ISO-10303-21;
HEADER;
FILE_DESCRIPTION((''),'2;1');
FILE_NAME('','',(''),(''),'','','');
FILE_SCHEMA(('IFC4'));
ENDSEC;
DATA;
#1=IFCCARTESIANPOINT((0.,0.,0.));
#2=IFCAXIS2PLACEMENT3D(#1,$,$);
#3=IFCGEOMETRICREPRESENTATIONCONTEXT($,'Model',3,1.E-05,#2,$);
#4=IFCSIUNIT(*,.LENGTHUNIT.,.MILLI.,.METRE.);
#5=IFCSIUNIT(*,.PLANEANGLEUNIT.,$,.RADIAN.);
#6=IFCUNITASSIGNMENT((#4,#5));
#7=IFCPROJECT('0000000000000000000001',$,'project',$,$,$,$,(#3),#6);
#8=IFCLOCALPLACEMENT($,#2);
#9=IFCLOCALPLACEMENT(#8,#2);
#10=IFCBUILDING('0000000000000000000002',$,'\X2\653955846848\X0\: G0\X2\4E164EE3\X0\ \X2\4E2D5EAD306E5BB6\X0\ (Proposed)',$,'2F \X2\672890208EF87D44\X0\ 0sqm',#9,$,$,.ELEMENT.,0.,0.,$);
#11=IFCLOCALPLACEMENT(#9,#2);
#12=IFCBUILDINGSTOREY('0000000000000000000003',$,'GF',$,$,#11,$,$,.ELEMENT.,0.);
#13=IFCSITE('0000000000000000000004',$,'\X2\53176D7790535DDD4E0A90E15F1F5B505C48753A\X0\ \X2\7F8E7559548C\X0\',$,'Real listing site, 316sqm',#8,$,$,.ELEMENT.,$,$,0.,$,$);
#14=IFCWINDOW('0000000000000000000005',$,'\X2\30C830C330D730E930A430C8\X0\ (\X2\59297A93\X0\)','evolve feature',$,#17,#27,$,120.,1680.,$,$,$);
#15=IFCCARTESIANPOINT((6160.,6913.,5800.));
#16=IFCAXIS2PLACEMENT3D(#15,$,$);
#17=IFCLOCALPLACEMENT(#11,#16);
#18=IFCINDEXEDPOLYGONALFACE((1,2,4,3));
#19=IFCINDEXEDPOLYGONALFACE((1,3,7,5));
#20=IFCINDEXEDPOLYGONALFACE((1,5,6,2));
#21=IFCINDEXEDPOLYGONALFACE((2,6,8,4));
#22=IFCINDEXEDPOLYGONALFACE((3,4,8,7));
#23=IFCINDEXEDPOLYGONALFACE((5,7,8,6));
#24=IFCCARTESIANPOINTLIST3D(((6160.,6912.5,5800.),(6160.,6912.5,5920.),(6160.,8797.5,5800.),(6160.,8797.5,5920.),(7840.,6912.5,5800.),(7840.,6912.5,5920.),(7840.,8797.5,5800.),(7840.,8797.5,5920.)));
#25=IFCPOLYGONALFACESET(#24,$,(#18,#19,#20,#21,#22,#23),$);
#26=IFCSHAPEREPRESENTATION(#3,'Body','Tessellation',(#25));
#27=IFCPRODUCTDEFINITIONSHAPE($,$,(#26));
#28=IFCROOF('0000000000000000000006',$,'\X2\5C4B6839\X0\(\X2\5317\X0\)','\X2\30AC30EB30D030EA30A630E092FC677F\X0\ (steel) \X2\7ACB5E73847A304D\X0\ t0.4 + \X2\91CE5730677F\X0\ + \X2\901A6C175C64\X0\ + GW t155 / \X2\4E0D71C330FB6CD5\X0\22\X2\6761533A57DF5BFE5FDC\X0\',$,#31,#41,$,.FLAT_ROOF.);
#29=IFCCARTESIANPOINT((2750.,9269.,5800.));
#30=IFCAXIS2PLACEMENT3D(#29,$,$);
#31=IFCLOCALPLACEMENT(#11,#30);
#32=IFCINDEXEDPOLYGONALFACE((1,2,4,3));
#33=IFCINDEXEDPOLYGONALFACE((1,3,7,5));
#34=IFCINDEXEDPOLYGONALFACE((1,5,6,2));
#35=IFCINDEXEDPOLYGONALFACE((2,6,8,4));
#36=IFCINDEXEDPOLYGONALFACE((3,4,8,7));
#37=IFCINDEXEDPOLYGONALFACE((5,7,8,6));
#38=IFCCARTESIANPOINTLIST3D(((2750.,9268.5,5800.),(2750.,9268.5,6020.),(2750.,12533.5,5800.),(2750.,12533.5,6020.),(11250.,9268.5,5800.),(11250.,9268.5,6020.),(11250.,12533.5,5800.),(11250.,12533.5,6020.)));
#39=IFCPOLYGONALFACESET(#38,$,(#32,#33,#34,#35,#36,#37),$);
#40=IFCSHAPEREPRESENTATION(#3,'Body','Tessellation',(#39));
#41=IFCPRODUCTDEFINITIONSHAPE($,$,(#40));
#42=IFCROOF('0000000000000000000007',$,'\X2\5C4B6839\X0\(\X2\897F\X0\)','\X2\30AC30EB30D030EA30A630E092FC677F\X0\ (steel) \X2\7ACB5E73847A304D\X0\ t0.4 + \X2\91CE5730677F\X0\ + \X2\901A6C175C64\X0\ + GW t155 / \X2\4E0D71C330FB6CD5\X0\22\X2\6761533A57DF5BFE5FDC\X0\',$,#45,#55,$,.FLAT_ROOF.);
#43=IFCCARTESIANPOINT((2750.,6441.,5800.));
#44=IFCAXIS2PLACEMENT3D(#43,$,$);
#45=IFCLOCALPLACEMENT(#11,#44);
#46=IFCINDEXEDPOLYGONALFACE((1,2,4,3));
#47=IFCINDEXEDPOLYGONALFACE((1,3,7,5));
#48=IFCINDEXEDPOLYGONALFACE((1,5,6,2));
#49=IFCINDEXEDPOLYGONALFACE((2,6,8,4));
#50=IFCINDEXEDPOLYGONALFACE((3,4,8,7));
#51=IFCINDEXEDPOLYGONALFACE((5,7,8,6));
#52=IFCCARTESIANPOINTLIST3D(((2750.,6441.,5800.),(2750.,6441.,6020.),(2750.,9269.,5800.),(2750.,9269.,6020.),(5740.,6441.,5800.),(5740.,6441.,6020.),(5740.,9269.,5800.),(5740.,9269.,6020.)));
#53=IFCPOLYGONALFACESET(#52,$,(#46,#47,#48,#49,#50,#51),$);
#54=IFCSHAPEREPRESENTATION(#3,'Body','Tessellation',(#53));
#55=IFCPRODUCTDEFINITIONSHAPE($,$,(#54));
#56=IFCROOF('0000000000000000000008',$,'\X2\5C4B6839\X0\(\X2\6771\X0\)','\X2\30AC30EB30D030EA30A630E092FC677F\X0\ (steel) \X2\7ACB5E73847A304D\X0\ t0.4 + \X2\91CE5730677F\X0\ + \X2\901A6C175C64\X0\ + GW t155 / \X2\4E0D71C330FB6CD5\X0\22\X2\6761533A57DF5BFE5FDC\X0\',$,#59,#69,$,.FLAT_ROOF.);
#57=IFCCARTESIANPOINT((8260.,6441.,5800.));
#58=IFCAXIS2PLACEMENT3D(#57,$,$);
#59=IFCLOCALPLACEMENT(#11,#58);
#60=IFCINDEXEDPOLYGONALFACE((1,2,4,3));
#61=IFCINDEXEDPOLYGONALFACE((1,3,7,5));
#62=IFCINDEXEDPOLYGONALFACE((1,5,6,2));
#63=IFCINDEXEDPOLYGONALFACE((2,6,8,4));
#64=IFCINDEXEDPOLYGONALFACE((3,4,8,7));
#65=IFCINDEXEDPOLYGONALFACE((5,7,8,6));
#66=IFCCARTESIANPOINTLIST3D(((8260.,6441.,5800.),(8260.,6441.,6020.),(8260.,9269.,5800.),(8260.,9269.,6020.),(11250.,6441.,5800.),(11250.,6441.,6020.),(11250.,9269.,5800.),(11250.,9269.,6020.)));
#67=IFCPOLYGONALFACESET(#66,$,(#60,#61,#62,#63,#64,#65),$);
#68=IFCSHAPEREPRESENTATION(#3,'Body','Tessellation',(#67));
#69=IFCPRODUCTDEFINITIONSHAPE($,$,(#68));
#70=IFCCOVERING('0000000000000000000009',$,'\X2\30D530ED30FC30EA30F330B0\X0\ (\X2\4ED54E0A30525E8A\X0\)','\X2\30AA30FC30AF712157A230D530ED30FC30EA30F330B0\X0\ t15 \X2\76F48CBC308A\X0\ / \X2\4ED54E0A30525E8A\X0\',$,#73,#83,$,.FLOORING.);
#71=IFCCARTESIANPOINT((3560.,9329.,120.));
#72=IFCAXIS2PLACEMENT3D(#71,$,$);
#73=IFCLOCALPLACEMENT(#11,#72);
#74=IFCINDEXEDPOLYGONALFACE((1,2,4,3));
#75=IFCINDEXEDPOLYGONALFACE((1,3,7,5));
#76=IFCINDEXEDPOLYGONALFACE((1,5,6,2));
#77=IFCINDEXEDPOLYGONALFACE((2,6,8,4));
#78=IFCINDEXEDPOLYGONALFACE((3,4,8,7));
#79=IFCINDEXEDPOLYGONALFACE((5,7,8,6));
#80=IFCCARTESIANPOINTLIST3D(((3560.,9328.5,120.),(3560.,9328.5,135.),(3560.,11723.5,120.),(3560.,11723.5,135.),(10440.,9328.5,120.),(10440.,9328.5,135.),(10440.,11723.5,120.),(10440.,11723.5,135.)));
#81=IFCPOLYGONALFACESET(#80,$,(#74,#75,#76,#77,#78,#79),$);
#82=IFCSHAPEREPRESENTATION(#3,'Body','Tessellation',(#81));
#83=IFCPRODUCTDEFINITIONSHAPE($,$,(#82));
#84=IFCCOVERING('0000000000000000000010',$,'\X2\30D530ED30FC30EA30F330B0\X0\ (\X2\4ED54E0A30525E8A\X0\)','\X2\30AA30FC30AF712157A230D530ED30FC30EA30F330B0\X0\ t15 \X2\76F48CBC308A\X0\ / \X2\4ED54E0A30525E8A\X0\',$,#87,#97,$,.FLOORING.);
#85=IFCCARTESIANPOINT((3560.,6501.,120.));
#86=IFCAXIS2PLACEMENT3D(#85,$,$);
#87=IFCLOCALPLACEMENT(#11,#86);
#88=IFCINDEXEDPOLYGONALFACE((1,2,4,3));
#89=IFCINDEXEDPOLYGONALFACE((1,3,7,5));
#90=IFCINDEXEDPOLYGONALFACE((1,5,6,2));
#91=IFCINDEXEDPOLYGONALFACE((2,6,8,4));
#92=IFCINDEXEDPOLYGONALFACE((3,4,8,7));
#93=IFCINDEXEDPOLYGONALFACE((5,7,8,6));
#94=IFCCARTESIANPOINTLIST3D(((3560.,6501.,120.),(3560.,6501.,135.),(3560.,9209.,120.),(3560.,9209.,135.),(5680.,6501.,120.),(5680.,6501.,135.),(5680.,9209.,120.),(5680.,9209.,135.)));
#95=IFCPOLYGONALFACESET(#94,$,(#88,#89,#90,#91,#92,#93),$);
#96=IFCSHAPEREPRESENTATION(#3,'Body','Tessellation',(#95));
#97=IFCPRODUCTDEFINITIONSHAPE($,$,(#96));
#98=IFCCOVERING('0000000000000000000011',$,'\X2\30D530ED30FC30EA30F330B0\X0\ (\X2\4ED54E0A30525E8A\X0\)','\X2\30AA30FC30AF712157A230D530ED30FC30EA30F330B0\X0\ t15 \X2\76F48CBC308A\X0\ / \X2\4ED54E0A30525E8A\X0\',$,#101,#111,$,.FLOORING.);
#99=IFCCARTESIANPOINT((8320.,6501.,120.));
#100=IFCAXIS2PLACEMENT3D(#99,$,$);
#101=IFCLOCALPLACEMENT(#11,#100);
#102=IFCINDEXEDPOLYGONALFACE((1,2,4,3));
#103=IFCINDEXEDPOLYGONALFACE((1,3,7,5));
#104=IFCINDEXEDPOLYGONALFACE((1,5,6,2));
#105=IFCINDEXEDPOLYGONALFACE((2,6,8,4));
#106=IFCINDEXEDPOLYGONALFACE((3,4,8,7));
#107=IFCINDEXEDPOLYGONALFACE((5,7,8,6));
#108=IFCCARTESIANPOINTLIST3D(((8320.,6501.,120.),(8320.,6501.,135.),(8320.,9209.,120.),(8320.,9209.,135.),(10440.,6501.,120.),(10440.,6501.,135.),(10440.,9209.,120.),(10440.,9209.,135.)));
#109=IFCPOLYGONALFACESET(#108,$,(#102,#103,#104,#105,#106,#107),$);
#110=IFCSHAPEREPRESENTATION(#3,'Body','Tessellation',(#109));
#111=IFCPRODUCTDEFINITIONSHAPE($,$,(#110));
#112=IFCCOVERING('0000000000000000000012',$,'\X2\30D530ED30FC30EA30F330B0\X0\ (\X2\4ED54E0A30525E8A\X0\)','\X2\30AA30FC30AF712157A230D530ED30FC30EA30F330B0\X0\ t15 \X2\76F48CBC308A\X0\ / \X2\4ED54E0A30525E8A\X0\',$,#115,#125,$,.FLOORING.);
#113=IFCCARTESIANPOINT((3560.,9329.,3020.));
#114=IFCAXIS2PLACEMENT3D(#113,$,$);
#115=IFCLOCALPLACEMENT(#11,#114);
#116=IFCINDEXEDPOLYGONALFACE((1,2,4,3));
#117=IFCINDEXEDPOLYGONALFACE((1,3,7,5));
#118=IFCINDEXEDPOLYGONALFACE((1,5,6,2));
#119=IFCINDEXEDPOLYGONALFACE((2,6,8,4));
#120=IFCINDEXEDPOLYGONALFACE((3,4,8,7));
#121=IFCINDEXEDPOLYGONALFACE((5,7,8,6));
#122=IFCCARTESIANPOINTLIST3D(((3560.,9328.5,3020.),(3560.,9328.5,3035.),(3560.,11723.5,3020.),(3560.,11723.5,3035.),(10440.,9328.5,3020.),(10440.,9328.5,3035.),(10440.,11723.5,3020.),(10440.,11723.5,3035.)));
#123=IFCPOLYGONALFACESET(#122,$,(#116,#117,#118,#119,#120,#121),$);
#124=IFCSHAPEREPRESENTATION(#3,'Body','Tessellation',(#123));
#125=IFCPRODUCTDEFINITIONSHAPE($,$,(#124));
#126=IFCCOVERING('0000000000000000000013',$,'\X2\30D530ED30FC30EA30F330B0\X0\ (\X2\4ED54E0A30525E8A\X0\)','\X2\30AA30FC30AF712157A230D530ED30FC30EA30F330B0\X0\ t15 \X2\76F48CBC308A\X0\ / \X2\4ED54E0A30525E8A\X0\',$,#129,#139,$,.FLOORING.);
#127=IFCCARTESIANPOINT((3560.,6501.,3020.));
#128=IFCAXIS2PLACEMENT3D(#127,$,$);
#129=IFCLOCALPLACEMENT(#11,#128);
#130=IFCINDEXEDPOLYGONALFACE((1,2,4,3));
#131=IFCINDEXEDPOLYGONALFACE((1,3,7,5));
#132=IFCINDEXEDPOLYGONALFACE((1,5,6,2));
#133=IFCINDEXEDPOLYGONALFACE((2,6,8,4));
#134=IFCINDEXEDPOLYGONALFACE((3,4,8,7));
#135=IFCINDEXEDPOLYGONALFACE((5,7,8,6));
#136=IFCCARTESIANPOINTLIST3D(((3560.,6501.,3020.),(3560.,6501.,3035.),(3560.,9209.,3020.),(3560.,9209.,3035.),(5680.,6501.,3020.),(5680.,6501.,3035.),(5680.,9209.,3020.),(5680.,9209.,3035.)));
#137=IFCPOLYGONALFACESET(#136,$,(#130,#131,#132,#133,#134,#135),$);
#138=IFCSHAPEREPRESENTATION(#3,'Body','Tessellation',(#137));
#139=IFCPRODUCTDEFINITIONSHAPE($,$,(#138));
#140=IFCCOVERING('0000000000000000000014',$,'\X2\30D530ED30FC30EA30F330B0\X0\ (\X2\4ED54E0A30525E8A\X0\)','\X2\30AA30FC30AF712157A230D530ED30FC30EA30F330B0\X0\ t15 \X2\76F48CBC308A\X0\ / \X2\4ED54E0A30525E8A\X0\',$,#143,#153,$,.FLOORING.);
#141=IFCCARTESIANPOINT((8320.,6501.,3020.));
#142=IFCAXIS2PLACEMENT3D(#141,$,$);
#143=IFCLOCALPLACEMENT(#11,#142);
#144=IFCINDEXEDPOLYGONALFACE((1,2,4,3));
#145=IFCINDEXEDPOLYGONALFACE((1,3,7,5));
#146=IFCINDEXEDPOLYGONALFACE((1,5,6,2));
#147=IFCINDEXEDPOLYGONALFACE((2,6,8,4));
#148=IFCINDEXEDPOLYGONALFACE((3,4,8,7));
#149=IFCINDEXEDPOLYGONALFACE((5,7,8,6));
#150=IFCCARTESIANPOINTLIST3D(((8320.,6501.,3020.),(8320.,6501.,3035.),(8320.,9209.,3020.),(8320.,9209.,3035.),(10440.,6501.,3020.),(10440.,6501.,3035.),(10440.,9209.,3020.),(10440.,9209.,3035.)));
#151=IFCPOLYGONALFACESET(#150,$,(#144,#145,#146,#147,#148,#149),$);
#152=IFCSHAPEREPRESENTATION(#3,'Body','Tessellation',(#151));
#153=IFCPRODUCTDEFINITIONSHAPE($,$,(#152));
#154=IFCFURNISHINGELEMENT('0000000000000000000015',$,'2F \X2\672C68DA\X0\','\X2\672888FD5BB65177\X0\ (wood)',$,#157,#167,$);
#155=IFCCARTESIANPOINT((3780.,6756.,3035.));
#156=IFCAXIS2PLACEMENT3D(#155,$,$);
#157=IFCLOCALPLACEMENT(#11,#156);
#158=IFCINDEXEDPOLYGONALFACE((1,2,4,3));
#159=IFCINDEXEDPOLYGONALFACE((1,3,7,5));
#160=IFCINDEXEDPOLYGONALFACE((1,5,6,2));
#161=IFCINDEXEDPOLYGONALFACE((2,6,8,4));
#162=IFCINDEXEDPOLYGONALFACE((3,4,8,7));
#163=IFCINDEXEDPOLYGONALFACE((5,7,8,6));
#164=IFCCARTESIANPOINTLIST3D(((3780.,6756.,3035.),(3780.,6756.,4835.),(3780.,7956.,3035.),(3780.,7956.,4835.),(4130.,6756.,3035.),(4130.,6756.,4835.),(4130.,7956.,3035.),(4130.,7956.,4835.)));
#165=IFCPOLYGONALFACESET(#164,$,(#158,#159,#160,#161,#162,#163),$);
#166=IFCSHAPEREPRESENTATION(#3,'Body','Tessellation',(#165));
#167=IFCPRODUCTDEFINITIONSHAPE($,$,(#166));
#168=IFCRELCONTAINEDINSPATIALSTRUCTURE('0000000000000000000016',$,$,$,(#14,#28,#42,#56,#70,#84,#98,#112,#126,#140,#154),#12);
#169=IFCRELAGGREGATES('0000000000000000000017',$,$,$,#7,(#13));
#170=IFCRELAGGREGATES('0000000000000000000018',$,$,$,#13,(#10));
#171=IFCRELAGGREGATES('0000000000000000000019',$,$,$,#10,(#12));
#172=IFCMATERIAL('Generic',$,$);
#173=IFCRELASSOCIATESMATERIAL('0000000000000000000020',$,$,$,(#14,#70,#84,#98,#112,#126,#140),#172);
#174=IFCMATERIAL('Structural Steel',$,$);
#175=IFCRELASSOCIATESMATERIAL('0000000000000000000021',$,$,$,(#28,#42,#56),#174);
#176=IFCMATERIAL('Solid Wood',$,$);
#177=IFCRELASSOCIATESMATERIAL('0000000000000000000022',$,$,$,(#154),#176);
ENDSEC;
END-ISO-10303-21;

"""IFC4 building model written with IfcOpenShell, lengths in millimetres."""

from ifc_helpers import new_model, si_unit, frame, frame_2d, origin, place, context, project, spatial, rectangle, extrude, material, element, save


model = new_model("IFC4")

# Units and contexts
model_context = context("Model", 3, precision=1e-05, world=origin())
ifc_project = project(units=[si_unit("LENGTHUNIT", "METRE", prefix="MILLI"), si_unit("PLANEANGLEUNIT", "RADIAN")], contexts=[model_context])

# Site, building, storey
site_placement = place(None, origin())
site = spatial("IfcSite", under=ifc_project, at=site_placement, Name="北海道川上郡弟子屈町 美留和", ObjectType="Real listing site, 316sqm", CompositionType="ELEMENT", RefElevation=0.0)
building_placement = place(site_placement, origin())
building = spatial("IfcBuilding", under=site, at=building_placement, Name="改善案: G0世代 中庭の家 (Proposed)", ObjectType="2F 木造軸組 0sqm", CompositionType="ELEMENT", ElevationOfRefHeight=0.0, ElevationOfTerrain=0.0)
storey_placement = place(building_placement, origin())
storey = spatial("IfcBuildingStorey", under=building, at=storey_placement, Name="GF", CompositionType="ELEMENT", Elevation=0.0)

# Shared definitions
ifc_material_1 = material(Name="Solid Wood")

# Window
ifc_material_2 = material(Name="Generic")
window_1_placement = place(storey_placement, frame((6160.0, 6913.0, 5800.0)))
element("IfcWindow", 1, at=window_1_placement, inside=storey, material=ifc_material_2, Name="トップライト (天窓)", Description="evolve feature", OverallHeight=120.0, OverallWidth=1680.0, context=model_context, shape_type="SweptSolid", body=[
    extrude(rectangle(XDim=1680.0, YDim=1885.0, at=frame_2d((840.0, 942.0))), frame((6160.0, 6913.0, 5800.0)), (0.0, 0.0, 1.0), 120.0),
])

# Roofs
ifc_material_3 = material(Name="Structural Steel")
roof_1_placement = place(storey_placement, frame((2750.0, 9269.0, 5800.0)))
element("IfcRoof", 2, at=roof_1_placement, inside=storey, material=ifc_material_3, Name="屋根(北)", Description="ガルバリウム鋼板 (steel) 立平葺き t0.4 + 野地板 + 通気層 + GW t155 / 不燃・法22条区域対応", PredefinedType="FLAT_ROOF", context=model_context, shape_type="SweptSolid", body=[
    extrude(rectangle(XDim=8500.0, YDim=3265.0, at=frame_2d((4250.0, 1632.0))), frame((2750.0, 9269.0, 5800.0)), (0.0, 0.0, 1.0), 220.0),
])
roof_2_placement = place(storey_placement, frame((2750.0, 6441.0, 5800.0)))
element("IfcRoof", 3, at=roof_2_placement, inside=storey, material=ifc_material_3, Name="屋根(西)", Description="ガルバリウム鋼板 (steel) 立平葺き t0.4 + 野地板 + 通気層 + GW t155 / 不燃・法22条区域対応", PredefinedType="FLAT_ROOF", context=model_context, shape_type="SweptSolid", body=[
    extrude(rectangle(XDim=2990.0, YDim=2828.0, at=frame_2d((1495.0, 1414.0))), frame((2750.0, 6441.0, 5800.0)), (0.0, 0.0, 1.0), 220.0),
])
roof_3_placement = place(storey_placement, frame((8260.0, 6441.0, 5800.0)))
element("IfcRoof", 4, at=roof_3_placement, inside=storey, material=ifc_material_3, Name="屋根(東)", Description="ガルバリウム鋼板 (steel) 立平葺き t0.4 + 野地板 + 通気層 + GW t155 / 不燃・法22条区域対応", PredefinedType="FLAT_ROOF", context=model_context, shape_type="SweptSolid", body=[
    extrude(rectangle(XDim=2990.0, YDim=2828.0, at=frame_2d((1495.0, 1414.0))), frame((8260.0, 6441.0, 5800.0)), (0.0, 0.0, 1.0), 220.0),
])

# Coverings
covering_1_placement = place(storey_placement, frame((3560.0, 9329.0, 120.0)))
element("IfcCovering", 5, at=covering_1_placement, inside=storey, material=ifc_material_2, Name="フローリング (仕上げ床)", Description="オーク無垢フローリング t15 直貼り / 仕上げ床", PredefinedType="FLOORING", context=model_context, shape_type="SweptSolid", body=[
    extrude(rectangle(XDim=6880.0, YDim=2395.0, at=frame_2d((3440.0, 1197.0))), frame((3560.0, 9329.0, 120.0)), (0.0, 0.0, 1.0), 15.0),
])
covering_2_placement = place(storey_placement, frame((3560.0, 6501.0, 120.0)))
element("IfcCovering", 6, at=covering_2_placement, inside=storey, material=ifc_material_2, Name="フローリング (仕上げ床)", Description="オーク無垢フローリング t15 直貼り / 仕上げ床", PredefinedType="FLOORING", context=model_context, shape_type="SweptSolid", body=[
    extrude(rectangle(XDim=2120.0, YDim=2708.0, at=frame_2d((1060.0, 1354.0))), frame((3560.0, 6501.0, 120.0)), (0.0, 0.0, 1.0), 15.0),
])
covering_3_placement = place(storey_placement, frame((8320.0, 6501.0, 120.0)))
element("IfcCovering", 7, at=covering_3_placement, inside=storey, material=ifc_material_2, Name="フローリング (仕上げ床)", Description="オーク無垢フローリング t15 直貼り / 仕上げ床", PredefinedType="FLOORING", context=model_context, shape_type="SweptSolid", body=[
    extrude(rectangle(XDim=2120.0, YDim=2708.0, at=frame_2d((1060.0, 1354.0))), frame((8320.0, 6501.0, 120.0)), (0.0, 0.0, 1.0), 15.0),
])
covering_4_placement = place(storey_placement, frame((3560.0, 9329.0, 3020.0)))
element("IfcCovering", 8, at=covering_4_placement, inside=storey, material=ifc_material_2, Name="フローリング (仕上げ床)", Description="オーク無垢フローリング t15 直貼り / 仕上げ床", PredefinedType="FLOORING", context=model_context, shape_type="SweptSolid", body=[
    extrude(rectangle(XDim=6880.0, YDim=2395.0, at=frame_2d((3440.0, 1197.0))), frame((3560.0, 9329.0, 3020.0)), (0.0, 0.0, 1.0), 15.0),
])
covering_5_placement = place(storey_placement, frame((3560.0, 6501.0, 3020.0)))
element("IfcCovering", 9, at=covering_5_placement, inside=storey, material=ifc_material_2, Name="フローリング (仕上げ床)", Description="オーク無垢フローリング t15 直貼り / 仕上げ床", PredefinedType="FLOORING", context=model_context, shape_type="SweptSolid", body=[
    extrude(rectangle(XDim=2120.0, YDim=2708.0, at=frame_2d((1060.0, 1354.0))), frame((3560.0, 6501.0, 3020.0)), (0.0, 0.0, 1.0), 15.0),
])
covering_6_placement = place(storey_placement, frame((8320.0, 6501.0, 3020.0)))
element("IfcCovering", 10, at=covering_6_placement, inside=storey, material=ifc_material_2, Name="フローリング (仕上げ床)", Description="オーク無垢フローリング t15 直貼り / 仕上げ床", PredefinedType="FLOORING", context=model_context, shape_type="SweptSolid", body=[
    extrude(rectangle(XDim=2120.0, YDim=2708.0, at=frame_2d((1060.0, 1354.0))), frame((8320.0, 6501.0, 3020.0)), (0.0, 0.0, 1.0), 15.0),
])

# Furnishing element
furnishing_placement = place(storey_placement, frame((3780.0, 6756.0, 3035.0)))
element("IfcFurnishingElement", 11, at=furnishing_placement, inside=storey, material=ifc_material_1, Name="2F 本棚", Description="木製家具 (wood)", context=model_context, shape_type="SweptSolid", body=[
    extrude(rectangle(XDim=350.0, YDim=1200.0, at=frame_2d((175.0, 600.0))), frame((3780.0, 6756.0, 3035.0)), (0.0, 0.0, 1.0), 1800.0),
])

save(model, "model.ifc")
